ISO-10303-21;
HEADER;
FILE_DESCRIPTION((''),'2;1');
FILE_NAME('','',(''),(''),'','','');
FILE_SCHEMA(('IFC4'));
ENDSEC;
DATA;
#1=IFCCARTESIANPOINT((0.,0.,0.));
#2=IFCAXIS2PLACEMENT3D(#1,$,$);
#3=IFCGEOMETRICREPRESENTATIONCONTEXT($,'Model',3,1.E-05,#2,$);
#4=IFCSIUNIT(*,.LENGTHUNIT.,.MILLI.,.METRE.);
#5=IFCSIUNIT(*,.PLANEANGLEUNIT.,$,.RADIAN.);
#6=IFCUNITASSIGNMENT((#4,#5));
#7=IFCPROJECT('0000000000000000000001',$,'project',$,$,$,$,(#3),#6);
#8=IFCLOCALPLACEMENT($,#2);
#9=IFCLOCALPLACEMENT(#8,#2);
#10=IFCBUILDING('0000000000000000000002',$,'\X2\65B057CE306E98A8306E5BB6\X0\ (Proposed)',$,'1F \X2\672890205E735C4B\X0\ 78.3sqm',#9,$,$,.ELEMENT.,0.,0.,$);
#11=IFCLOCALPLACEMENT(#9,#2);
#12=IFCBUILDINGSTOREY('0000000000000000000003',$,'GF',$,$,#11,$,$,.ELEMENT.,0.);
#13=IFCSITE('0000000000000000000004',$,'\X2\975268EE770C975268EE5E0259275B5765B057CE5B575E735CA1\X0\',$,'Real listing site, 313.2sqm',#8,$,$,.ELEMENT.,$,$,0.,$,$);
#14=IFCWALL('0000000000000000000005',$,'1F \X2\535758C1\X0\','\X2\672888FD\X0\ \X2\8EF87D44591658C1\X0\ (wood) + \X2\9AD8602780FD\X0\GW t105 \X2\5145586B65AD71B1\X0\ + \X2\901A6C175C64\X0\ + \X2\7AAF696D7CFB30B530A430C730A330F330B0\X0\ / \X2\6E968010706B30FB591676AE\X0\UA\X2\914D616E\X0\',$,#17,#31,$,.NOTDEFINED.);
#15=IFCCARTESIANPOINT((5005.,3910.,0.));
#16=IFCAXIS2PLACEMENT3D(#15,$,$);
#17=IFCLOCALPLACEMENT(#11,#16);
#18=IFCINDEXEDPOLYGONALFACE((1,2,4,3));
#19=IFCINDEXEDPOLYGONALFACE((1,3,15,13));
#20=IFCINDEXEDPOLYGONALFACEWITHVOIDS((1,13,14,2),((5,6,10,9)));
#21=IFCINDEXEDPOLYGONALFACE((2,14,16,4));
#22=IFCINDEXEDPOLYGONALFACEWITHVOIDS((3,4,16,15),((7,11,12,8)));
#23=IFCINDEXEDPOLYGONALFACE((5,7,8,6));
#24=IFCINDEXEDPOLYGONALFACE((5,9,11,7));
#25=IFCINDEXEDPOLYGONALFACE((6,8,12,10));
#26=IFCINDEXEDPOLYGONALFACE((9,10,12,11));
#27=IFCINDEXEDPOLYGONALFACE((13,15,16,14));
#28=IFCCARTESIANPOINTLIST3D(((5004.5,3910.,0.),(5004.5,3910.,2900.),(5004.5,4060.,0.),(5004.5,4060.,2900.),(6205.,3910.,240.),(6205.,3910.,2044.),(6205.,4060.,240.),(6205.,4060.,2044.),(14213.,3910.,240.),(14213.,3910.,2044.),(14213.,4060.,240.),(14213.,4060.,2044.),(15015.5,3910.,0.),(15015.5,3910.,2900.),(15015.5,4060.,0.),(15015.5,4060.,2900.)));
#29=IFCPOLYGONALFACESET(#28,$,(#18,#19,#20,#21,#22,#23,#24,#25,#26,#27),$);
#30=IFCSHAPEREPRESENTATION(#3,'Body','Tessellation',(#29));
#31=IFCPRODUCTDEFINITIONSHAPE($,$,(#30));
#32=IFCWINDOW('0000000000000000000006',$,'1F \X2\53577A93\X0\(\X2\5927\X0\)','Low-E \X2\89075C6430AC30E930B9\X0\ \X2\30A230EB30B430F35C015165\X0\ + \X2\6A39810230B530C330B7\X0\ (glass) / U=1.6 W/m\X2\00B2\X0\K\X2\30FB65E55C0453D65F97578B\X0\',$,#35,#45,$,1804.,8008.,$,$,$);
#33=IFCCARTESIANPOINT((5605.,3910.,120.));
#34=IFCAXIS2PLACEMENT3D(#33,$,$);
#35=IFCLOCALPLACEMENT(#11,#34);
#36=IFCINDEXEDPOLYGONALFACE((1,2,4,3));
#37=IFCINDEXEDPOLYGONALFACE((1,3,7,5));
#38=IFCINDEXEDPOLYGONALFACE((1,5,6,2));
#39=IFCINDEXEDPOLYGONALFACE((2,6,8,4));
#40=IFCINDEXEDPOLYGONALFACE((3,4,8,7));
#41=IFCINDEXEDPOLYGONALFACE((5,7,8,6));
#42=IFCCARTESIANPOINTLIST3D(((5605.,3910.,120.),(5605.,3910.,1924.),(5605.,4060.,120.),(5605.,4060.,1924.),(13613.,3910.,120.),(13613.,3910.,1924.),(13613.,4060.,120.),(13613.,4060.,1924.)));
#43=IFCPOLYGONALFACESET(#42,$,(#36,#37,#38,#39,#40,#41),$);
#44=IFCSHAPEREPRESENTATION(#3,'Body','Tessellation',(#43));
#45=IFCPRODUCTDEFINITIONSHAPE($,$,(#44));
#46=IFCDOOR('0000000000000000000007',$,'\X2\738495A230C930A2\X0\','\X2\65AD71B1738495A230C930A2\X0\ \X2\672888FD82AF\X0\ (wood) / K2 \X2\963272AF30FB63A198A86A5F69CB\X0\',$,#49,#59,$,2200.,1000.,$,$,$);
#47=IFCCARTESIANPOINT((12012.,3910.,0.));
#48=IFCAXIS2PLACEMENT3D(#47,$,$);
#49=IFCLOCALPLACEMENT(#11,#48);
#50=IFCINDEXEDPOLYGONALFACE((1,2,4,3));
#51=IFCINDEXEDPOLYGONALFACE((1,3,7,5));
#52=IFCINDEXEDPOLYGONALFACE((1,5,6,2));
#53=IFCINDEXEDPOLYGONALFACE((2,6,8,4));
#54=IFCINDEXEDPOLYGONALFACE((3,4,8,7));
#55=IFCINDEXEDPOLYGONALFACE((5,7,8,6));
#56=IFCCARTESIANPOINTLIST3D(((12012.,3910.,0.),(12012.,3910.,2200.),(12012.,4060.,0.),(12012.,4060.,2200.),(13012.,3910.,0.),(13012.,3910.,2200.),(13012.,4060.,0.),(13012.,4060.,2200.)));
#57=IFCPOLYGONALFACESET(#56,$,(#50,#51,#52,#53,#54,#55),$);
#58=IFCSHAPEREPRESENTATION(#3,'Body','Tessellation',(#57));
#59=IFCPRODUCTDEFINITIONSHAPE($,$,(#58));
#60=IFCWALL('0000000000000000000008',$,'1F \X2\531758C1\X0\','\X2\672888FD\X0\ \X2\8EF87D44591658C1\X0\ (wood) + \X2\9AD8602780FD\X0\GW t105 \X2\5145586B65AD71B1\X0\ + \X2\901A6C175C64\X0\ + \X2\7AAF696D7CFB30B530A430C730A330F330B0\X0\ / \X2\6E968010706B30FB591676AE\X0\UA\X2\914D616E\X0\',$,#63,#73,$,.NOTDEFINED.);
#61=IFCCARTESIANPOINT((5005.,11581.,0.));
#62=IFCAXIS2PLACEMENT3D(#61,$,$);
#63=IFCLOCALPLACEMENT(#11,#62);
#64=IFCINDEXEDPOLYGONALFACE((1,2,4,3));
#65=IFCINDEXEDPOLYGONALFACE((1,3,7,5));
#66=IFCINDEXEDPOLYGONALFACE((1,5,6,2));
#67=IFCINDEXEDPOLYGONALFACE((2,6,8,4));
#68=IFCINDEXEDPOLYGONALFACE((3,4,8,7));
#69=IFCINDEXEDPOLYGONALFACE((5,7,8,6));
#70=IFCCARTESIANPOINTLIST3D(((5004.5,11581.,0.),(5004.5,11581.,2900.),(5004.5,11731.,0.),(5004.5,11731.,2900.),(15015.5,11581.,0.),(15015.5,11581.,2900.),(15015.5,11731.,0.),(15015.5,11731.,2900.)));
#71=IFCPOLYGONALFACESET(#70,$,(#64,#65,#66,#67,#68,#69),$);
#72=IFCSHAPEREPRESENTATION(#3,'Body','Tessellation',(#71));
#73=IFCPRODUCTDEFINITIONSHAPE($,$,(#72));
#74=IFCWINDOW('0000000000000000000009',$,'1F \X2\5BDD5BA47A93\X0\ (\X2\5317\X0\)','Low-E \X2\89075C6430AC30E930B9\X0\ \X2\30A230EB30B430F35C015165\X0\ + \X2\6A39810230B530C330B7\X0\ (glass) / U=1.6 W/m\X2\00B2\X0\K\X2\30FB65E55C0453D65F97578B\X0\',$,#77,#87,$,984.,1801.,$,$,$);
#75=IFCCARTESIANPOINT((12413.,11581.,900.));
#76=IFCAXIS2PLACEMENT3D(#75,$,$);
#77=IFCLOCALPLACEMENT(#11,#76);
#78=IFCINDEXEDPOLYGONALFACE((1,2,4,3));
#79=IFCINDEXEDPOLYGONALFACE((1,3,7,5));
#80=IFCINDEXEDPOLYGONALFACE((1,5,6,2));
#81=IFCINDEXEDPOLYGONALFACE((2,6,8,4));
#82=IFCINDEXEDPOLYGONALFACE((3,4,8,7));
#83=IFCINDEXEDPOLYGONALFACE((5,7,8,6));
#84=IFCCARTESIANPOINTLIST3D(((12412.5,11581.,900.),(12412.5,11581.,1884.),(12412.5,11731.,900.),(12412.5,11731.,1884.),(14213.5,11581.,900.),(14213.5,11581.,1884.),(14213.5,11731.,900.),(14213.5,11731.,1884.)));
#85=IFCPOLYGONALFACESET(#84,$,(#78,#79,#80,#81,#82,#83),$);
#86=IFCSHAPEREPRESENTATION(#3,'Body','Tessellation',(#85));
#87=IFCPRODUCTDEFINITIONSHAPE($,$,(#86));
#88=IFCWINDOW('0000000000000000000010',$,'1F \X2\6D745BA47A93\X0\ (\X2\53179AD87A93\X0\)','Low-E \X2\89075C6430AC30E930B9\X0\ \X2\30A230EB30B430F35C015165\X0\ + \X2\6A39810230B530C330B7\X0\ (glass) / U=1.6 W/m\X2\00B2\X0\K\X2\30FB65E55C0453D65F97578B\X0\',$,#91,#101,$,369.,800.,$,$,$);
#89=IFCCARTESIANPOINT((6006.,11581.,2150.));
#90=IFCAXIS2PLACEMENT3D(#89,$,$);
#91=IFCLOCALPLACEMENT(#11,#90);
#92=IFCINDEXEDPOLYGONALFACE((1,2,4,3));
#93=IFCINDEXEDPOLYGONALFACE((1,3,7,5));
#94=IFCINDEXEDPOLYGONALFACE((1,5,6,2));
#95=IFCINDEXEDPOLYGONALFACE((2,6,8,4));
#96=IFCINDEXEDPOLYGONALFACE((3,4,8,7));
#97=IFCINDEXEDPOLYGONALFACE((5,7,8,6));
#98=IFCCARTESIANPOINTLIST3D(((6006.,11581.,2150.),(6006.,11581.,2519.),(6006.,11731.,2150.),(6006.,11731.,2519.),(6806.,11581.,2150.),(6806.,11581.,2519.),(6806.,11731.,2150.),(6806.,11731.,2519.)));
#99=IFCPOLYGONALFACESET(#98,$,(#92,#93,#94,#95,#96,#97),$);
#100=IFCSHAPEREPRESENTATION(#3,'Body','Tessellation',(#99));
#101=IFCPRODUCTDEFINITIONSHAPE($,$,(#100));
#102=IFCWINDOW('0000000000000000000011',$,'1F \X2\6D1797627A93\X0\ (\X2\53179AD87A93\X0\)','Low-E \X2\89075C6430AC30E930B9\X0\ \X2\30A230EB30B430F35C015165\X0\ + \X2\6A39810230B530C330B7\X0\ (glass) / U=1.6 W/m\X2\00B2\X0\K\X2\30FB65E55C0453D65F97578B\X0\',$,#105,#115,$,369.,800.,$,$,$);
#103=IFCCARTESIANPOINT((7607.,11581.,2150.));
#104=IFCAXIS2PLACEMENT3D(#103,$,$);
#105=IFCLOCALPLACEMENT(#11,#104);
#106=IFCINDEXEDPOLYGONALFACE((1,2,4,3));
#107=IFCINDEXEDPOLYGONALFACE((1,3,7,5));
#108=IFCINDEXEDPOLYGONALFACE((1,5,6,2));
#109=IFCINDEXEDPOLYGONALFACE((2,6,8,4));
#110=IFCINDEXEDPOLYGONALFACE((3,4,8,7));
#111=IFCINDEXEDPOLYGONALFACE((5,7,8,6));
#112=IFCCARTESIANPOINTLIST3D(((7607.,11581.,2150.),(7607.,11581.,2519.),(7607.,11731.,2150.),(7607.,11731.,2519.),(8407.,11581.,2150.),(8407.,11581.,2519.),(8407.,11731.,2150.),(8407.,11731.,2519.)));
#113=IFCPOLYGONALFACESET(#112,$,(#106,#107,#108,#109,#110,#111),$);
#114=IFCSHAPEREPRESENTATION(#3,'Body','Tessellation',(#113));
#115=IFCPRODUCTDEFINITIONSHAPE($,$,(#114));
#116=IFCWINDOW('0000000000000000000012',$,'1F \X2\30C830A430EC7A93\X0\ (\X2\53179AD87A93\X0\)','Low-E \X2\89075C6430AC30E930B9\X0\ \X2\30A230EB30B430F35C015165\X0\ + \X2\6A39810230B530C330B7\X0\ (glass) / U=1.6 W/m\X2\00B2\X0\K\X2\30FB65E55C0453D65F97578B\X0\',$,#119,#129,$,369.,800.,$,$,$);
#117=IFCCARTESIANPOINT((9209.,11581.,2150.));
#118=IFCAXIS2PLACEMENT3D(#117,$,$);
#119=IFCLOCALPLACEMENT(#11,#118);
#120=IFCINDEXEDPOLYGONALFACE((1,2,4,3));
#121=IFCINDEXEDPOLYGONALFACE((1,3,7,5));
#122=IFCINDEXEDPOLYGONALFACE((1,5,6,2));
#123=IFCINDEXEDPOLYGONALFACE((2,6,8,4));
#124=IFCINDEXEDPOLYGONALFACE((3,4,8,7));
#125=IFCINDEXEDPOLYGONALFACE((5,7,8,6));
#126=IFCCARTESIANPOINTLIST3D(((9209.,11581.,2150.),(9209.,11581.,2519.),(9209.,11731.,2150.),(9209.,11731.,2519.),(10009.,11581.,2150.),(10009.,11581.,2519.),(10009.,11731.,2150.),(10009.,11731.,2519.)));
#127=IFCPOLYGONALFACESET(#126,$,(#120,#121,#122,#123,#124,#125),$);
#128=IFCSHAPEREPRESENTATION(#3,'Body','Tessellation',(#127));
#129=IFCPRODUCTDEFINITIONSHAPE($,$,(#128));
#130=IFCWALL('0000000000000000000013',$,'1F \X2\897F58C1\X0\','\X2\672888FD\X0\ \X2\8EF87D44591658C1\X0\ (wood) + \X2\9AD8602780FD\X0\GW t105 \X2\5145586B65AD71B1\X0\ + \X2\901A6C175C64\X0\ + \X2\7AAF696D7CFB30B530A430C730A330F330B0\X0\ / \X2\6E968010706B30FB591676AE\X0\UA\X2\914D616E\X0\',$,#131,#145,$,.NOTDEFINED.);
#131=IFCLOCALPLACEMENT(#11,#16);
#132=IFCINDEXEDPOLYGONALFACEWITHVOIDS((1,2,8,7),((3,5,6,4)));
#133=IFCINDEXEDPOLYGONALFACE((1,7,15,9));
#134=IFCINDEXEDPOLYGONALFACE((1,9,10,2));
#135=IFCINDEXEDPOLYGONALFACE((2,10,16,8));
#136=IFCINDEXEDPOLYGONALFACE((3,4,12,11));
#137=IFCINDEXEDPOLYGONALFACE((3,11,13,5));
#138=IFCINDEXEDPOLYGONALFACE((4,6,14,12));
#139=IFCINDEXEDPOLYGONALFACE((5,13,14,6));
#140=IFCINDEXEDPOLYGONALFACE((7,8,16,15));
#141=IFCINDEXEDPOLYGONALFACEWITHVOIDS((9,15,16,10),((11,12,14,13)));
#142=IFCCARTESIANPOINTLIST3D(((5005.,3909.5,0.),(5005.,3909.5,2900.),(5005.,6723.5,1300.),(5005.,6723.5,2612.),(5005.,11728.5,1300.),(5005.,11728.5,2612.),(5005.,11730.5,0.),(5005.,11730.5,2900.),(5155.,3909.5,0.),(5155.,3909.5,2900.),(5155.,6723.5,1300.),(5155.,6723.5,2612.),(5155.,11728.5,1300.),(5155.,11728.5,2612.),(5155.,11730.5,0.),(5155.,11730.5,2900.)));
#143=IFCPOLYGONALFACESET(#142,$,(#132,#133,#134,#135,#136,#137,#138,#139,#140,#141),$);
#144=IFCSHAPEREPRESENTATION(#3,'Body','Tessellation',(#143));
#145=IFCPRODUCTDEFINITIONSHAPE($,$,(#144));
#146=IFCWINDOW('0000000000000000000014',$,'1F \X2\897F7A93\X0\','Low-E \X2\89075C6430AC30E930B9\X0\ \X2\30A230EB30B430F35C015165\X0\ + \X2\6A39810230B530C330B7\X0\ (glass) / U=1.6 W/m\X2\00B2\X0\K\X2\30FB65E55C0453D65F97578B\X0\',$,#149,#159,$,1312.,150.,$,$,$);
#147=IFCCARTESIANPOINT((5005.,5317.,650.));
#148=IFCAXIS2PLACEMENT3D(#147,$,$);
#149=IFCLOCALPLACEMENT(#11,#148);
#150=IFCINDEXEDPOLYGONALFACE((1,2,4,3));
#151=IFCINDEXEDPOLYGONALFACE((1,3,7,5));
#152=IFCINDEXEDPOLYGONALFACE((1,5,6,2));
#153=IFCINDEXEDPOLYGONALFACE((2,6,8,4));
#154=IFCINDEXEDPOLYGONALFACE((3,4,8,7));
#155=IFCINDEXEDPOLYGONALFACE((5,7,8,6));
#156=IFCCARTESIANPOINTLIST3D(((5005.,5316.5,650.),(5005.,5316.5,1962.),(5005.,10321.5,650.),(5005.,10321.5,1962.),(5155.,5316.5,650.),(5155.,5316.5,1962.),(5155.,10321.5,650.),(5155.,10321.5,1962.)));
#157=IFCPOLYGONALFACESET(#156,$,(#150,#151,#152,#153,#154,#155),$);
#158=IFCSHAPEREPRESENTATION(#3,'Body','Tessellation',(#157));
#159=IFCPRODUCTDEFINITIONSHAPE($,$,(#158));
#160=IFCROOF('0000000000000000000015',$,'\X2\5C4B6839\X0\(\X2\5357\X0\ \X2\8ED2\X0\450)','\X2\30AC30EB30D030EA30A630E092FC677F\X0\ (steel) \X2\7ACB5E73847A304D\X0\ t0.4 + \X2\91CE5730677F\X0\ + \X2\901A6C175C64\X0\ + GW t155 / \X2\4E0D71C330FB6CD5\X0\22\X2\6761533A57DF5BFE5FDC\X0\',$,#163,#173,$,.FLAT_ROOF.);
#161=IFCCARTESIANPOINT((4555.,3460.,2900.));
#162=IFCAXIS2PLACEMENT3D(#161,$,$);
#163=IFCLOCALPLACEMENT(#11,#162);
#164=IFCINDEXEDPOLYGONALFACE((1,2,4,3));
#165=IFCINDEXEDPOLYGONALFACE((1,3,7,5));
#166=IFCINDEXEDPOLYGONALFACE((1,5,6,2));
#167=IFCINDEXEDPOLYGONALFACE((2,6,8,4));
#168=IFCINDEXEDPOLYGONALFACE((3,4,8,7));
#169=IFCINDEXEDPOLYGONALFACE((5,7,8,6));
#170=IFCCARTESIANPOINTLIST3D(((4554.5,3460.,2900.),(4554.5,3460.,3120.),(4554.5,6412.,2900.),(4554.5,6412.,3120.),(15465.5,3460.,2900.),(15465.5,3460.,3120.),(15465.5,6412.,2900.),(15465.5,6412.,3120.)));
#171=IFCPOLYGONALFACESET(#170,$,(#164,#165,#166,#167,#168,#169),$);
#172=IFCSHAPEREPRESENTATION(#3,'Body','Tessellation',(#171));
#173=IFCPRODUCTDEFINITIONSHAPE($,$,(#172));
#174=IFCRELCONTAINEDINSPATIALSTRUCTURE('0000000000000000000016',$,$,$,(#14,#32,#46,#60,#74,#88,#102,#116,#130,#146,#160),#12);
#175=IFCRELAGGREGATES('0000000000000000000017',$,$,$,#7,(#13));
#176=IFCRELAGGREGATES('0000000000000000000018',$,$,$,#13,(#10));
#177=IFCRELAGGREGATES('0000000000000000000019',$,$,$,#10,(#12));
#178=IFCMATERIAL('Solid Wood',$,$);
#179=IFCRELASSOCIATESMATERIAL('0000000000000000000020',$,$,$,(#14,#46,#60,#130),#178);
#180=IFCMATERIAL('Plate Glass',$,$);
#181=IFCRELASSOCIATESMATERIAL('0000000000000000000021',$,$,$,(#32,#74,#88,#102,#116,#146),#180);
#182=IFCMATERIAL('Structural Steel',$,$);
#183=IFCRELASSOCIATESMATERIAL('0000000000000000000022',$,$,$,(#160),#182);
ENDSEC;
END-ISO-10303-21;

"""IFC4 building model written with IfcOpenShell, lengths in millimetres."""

from ifc_helpers import new_model, si_unit, frame, frame_2d, origin, place, context, project, spatial, rectangle, extrude, material, element, fill, save


model = new_model("IFC4")

# Units and contexts
model_context = context("Model", 3, precision=1e-05, world=origin())
ifc_project = project(units=[si_unit("LENGTHUNIT", "METRE", prefix="MILLI"), si_unit("PLANEANGLEUNIT", "RADIAN")], contexts=[model_context])

# Site, building, storey
site_placement = place(None, origin())
site = spatial("IfcSite", under=ifc_project, at=site_placement, Name="青森県青森市大字新城字平岡", ObjectType="Real listing site, 313.2sqm", CompositionType="ELEMENT", RefElevation=0.0)
building_placement = place(site_placement, origin())
building = spatial("IfcBuilding", under=site, at=building_placement, Name="新城の風の家 (Proposed)", ObjectType="1F 木造平屋 78.3sqm", CompositionType="ELEMENT", ElevationOfRefHeight=0.0, ElevationOfTerrain=0.0)
storey_placement = place(building_placement, origin())
storey = spatial("IfcBuildingStorey", under=building, at=storey_placement, Name="GF", CompositionType="ELEMENT", Elevation=0.0)

# Shared definitions
ifc_material_1 = material(Name="Solid Wood")

# Wall, openings, window, door
wall_1_placement = place(storey_placement, frame((5005.0, 3910.0, 0.0)))
wall_1 = element("IfcWall", 1, at=wall_1_placement, inside=storey, material=ifc_material_1, Name="1F 南壁", Description="木製 軸組外壁 (wood) + 高性能GW t105 充填断熱 + 通気層 + 窯業系サイディング / 準耐火・外皮UA配慮", PredefinedType="NOTDEFINED", context=model_context, shape_type="SweptSolid", body=[
    extrude(rectangle(XDim=10011.0, YDim=150.0, at=frame_2d((5005.0, 75.0))), frame((5005.0, 3910.0, 0.0)), (0.0, 0.0, 1.0), 2900.0),
])
opening_1_placement = place(storey_placement, frame((5605.0, 3910.0, 120.0)))
opening_1 = element("IfcOpeningElement", 2, at=opening_1_placement, cuts=wall_1, PredefinedType="NOTDEFINED", context=model_context, shape_type="SweptSolid", body=[
    extrude(rectangle(XDim=8008.0, YDim=150.0, at=frame_2d((4004.0, 75.0))), frame((5605.0, 3910.0, 120.0)), (0.0, 0.0, 1.0), 1804.0),
])
opening_2_placement = place(storey_placement, frame((12012.0, 3910.0, 0.0)))
opening_2 = element("IfcOpeningElement", 3, at=opening_2_placement, cuts=wall_1, PredefinedType="NOTDEFINED", context=model_context, shape_type="SweptSolid", body=[
    extrude(rectangle(XDim=1000.0, YDim=150.0, at=frame_2d((500.0, 75.0))), frame((12012.0, 3910.0, 0.0)), (0.0, 0.0, 1.0), 2200.0),
])
ifc_material_2 = material(Name="Plate Glass")
window_1_placement = place(storey_placement, frame((5605.0, 3910.0, 120.0)))
window_1 = element("IfcWindow", 4, at=window_1_placement, inside=storey, material=ifc_material_2, Name="1F 南窓(大)", Description="Low-E 複層ガラス アルゴン封入 + 樹脂サッシ (glass) / U=1.6 W/m²K・日射取得型", OverallHeight=1804.0, OverallWidth=8008.0, context=model_context, shape_type="SweptSolid", body=[
    extrude(rectangle(XDim=8008.0, YDim=150.0, at=frame_2d((4004.0, 75.0))), frame((5605.0, 3910.0, 120.0)), (0.0, 0.0, 1.0), 1804.0),
])
fill(opening_1, window_1)
door_1_placement = place(storey_placement, frame((12012.0, 3910.0, 0.0)))
door_1 = element("IfcDoor", 5, at=door_1_placement, inside=storey, material=ifc_material_1, Name="玄関ドア", Description="断熱玄関ドア 木製芯 (wood) / K2 防犯・採風機構", OverallHeight=2200.0, OverallWidth=1000.0, context=model_context, shape_type="SweptSolid", body=[
    extrude(rectangle(XDim=1000.0, YDim=150.0, at=frame_2d((500.0, 75.0))), frame((12012.0, 3910.0, 0.0)), (0.0, 0.0, 1.0), 2200.0),
])
fill(opening_2, door_1)

# Wall, openings, windows
wall_2_placement = place(storey_placement, frame((5005.0, 11581.0, 0.0)))
wall_2 = element("IfcWall", 6, at=wall_2_placement, inside=storey, material=ifc_material_1, Name="1F 北壁", Description="木製 軸組外壁 (wood) + 高性能GW t105 充填断熱 + 通気層 + 窯業系サイディング / 準耐火・外皮UA配慮", PredefinedType="NOTDEFINED", context=model_context, shape_type="SweptSolid", body=[
    extrude(rectangle(XDim=10011.0, YDim=150.0, at=frame_2d((5005.0, 75.0))), frame((5005.0, 11581.0, 0.0)), (0.0, 0.0, 1.0), 2900.0),
])
opening_3_placement = place(storey_placement, frame((12413.0, 11581.0, 900.0)))
opening_3 = element("IfcOpeningElement", 7, at=opening_3_placement, cuts=wall_2, PredefinedType="NOTDEFINED", context=model_context, shape_type="SweptSolid", body=[
    extrude(rectangle(XDim=1801.0, YDim=150.0, at=frame_2d((900.0, 75.0))), frame((12413.0, 11581.0, 900.0)), (0.0, 0.0, 1.0), 984.0),
])
opening_4_placement = place(storey_placement, frame((6006.0, 11581.0, 2150.0)))
opening_4 = element("IfcOpeningElement", 8, at=opening_4_placement, cuts=wall_2, PredefinedType="NOTDEFINED", context=model_context, shape_type="SweptSolid", body=[
    extrude(rectangle(XDim=800.0, YDim=150.0, at=frame_2d((400.0, 75.0))), frame((6006.0, 11581.0, 2150.0)), (0.0, 0.0, 1.0), 369.0),
])
opening_5_placement = place(storey_placement, frame((7607.0, 11581.0, 2150.0)))
opening_5 = element("IfcOpeningElement", 9, at=opening_5_placement, cuts=wall_2, PredefinedType="NOTDEFINED", context=model_context, shape_type="SweptSolid", body=[
    extrude(rectangle(XDim=800.0, YDim=150.0, at=frame_2d((400.0, 75.0))), frame((7607.0, 11581.0, 2150.0)), (0.0, 0.0, 1.0), 369.0),
])
opening_6_placement = place(storey_placement, frame((9209.0, 11581.0, 2150.0)))
opening_6 = element("IfcOpeningElement", 10, at=opening_6_placement, cuts=wall_2, PredefinedType="NOTDEFINED", context=model_context, shape_type="SweptSolid", body=[
    extrude(rectangle(XDim=800.0, YDim=150.0, at=frame_2d((400.0, 75.0))), frame((9209.0, 11581.0, 2150.0)), (0.0, 0.0, 1.0), 369.0),
])
window_2_placement = place(storey_placement, frame((12413.0, 11581.0, 900.0)))
window_2 = element("IfcWindow", 11, at=window_2_placement, inside=storey, material=ifc_material_2, Name="1F 寝室窓 (北)", Description="Low-E 複層ガラス アルゴン封入 + 樹脂サッシ (glass) / U=1.6 W/m²K・日射取得型", OverallHeight=984.0, OverallWidth=1801.0, context=model_context, shape_type="SweptSolid", body=[
    extrude(rectangle(XDim=1801.0, YDim=150.0, at=frame_2d((900.0, 75.0))), frame((12413.0, 11581.0, 900.0)), (0.0, 0.0, 1.0), 984.0),
])
fill(opening_3, window_2)
window_3_placement = place(storey_placement, frame((6006.0, 11581.0, 2150.0)))
window_3 = element("IfcWindow", 12, at=window_3_placement, inside=storey, material=ifc_material_2, Name="1F 浴室窓 (北高窓)", Description="Low-E 複層ガラス アルゴン封入 + 樹脂サッシ (glass) / U=1.6 W/m²K・日射取得型", OverallHeight=369.0, OverallWidth=800.0, context=model_context, shape_type="SweptSolid", body=[
    extrude(rectangle(XDim=800.0, YDim=150.0, at=frame_2d((400.0, 75.0))), frame((6006.0, 11581.0, 2150.0)), (0.0, 0.0, 1.0), 369.0),
])
fill(opening_4, window_3)
window_4_placement = place(storey_placement, frame((7607.0, 11581.0, 2150.0)))
window_4 = element("IfcWindow", 13, at=window_4_placement, inside=storey, material=ifc_material_2, Name="1F 洗面窓 (北高窓)", Description="Low-E 複層ガラス アルゴン封入 + 樹脂サッシ (glass) / U=1.6 W/m²K・日射取得型", OverallHeight=369.0, OverallWidth=800.0, context=model_context, shape_type="SweptSolid", body=[
    extrude(rectangle(XDim=800.0, YDim=150.0, at=frame_2d((400.0, 75.0))), frame((7607.0, 11581.0, 2150.0)), (0.0, 0.0, 1.0), 369.0),
])
fill(opening_5, window_4)
window_5_placement = place(storey_placement, frame((9209.0, 11581.0, 2150.0)))
window_5 = element("IfcWindow", 14, at=window_5_placement, inside=storey, material=ifc_material_2, Name="1F トイレ窓 (北高窓)", Description="Low-E 複層ガラス アルゴン封入 + 樹脂サッシ (glass) / U=1.6 W/m²K・日射取得型", OverallHeight=369.0, OverallWidth=800.0, context=model_context, shape_type="SweptSolid", body=[
    extrude(rectangle(XDim=800.0, YDim=150.0, at=frame_2d((400.0, 75.0))), frame((9209.0, 11581.0, 2150.0)), (0.0, 0.0, 1.0), 369.0),
])
fill(opening_6, window_5)

# Wall, opening, window
wall_3_placement = place(storey_placement, frame((5005.0, 3910.0, 0.0)))
wall_3 = element("IfcWall", 15, at=wall_3_placement, inside=storey, material=ifc_material_1, Name="1F 西壁", Description="木製 軸組外壁 (wood) + 高性能GW t105 充填断熱 + 通気層 + 窯業系サイディング / 準耐火・外皮UA配慮", PredefinedType="NOTDEFINED", context=model_context, shape_type="SweptSolid", body=[
    extrude(rectangle(XDim=150.0, YDim=7821.0, at=frame_2d((75.0, 3910.0))), frame((5005.0, 3910.0, 0.0)), (0.0, 0.0, 1.0), 2900.0),
])
opening_7_placement = place(storey_placement, frame((5005.0, 5317.0, 650.0)))
opening_7 = element("IfcOpeningElement", 16, at=opening_7_placement, cuts=wall_3, PredefinedType="NOTDEFINED", context=model_context, shape_type="SweptSolid", body=[
    extrude(rectangle(XDim=150.0, YDim=5005.0, at=frame_2d((75.0, 2502.0))), frame((5005.0, 5317.0, 650.0)), (0.0, 0.0, 1.0), 1312.0),
])
window_6_placement = place(storey_placement, frame((5005.0, 5317.0, 650.0)))
window_6 = element("IfcWindow", 17, at=window_6_placement, inside=storey, material=ifc_material_2, Name="1F 西窓", Description="Low-E 複層ガラス アルゴン封入 + 樹脂サッシ (glass) / U=1.6 W/m²K・日射取得型", OverallHeight=1312.0, OverallWidth=150.0, context=model_context, shape_type="SweptSolid", body=[
    extrude(rectangle(XDim=150.0, YDim=5005.0, at=frame_2d((75.0, 2502.0))), frame((5005.0, 5317.0, 650.0)), (0.0, 0.0, 1.0), 1312.0),
])
fill(opening_7, window_6)

# Roof
ifc_material_3 = material(Name="Structural Steel")
roof_1_placement = place(storey_placement, frame((4555.0, 3460.0, 2900.0)))
element("IfcRoof", 18, at=roof_1_placement, inside=storey, material=ifc_material_3, Name="屋根(南 軒450)", Description="ガルバリウム鋼板 (steel) 立平葺き t0.4 + 野地板 + 通気層 + GW t155 / 不燃・法22条区域対応", PredefinedType="FLAT_ROOF", context=model_context, shape_type="SweptSolid", body=[
    extrude(rectangle(XDim=10911.0, YDim=2952.0, at=frame_2d((5455.0, 1476.0))), frame((4555.0, 3460.0, 2900.0)), (0.0, 0.0, 1.0), 220.0),
])

save(model, "model.ifc")
